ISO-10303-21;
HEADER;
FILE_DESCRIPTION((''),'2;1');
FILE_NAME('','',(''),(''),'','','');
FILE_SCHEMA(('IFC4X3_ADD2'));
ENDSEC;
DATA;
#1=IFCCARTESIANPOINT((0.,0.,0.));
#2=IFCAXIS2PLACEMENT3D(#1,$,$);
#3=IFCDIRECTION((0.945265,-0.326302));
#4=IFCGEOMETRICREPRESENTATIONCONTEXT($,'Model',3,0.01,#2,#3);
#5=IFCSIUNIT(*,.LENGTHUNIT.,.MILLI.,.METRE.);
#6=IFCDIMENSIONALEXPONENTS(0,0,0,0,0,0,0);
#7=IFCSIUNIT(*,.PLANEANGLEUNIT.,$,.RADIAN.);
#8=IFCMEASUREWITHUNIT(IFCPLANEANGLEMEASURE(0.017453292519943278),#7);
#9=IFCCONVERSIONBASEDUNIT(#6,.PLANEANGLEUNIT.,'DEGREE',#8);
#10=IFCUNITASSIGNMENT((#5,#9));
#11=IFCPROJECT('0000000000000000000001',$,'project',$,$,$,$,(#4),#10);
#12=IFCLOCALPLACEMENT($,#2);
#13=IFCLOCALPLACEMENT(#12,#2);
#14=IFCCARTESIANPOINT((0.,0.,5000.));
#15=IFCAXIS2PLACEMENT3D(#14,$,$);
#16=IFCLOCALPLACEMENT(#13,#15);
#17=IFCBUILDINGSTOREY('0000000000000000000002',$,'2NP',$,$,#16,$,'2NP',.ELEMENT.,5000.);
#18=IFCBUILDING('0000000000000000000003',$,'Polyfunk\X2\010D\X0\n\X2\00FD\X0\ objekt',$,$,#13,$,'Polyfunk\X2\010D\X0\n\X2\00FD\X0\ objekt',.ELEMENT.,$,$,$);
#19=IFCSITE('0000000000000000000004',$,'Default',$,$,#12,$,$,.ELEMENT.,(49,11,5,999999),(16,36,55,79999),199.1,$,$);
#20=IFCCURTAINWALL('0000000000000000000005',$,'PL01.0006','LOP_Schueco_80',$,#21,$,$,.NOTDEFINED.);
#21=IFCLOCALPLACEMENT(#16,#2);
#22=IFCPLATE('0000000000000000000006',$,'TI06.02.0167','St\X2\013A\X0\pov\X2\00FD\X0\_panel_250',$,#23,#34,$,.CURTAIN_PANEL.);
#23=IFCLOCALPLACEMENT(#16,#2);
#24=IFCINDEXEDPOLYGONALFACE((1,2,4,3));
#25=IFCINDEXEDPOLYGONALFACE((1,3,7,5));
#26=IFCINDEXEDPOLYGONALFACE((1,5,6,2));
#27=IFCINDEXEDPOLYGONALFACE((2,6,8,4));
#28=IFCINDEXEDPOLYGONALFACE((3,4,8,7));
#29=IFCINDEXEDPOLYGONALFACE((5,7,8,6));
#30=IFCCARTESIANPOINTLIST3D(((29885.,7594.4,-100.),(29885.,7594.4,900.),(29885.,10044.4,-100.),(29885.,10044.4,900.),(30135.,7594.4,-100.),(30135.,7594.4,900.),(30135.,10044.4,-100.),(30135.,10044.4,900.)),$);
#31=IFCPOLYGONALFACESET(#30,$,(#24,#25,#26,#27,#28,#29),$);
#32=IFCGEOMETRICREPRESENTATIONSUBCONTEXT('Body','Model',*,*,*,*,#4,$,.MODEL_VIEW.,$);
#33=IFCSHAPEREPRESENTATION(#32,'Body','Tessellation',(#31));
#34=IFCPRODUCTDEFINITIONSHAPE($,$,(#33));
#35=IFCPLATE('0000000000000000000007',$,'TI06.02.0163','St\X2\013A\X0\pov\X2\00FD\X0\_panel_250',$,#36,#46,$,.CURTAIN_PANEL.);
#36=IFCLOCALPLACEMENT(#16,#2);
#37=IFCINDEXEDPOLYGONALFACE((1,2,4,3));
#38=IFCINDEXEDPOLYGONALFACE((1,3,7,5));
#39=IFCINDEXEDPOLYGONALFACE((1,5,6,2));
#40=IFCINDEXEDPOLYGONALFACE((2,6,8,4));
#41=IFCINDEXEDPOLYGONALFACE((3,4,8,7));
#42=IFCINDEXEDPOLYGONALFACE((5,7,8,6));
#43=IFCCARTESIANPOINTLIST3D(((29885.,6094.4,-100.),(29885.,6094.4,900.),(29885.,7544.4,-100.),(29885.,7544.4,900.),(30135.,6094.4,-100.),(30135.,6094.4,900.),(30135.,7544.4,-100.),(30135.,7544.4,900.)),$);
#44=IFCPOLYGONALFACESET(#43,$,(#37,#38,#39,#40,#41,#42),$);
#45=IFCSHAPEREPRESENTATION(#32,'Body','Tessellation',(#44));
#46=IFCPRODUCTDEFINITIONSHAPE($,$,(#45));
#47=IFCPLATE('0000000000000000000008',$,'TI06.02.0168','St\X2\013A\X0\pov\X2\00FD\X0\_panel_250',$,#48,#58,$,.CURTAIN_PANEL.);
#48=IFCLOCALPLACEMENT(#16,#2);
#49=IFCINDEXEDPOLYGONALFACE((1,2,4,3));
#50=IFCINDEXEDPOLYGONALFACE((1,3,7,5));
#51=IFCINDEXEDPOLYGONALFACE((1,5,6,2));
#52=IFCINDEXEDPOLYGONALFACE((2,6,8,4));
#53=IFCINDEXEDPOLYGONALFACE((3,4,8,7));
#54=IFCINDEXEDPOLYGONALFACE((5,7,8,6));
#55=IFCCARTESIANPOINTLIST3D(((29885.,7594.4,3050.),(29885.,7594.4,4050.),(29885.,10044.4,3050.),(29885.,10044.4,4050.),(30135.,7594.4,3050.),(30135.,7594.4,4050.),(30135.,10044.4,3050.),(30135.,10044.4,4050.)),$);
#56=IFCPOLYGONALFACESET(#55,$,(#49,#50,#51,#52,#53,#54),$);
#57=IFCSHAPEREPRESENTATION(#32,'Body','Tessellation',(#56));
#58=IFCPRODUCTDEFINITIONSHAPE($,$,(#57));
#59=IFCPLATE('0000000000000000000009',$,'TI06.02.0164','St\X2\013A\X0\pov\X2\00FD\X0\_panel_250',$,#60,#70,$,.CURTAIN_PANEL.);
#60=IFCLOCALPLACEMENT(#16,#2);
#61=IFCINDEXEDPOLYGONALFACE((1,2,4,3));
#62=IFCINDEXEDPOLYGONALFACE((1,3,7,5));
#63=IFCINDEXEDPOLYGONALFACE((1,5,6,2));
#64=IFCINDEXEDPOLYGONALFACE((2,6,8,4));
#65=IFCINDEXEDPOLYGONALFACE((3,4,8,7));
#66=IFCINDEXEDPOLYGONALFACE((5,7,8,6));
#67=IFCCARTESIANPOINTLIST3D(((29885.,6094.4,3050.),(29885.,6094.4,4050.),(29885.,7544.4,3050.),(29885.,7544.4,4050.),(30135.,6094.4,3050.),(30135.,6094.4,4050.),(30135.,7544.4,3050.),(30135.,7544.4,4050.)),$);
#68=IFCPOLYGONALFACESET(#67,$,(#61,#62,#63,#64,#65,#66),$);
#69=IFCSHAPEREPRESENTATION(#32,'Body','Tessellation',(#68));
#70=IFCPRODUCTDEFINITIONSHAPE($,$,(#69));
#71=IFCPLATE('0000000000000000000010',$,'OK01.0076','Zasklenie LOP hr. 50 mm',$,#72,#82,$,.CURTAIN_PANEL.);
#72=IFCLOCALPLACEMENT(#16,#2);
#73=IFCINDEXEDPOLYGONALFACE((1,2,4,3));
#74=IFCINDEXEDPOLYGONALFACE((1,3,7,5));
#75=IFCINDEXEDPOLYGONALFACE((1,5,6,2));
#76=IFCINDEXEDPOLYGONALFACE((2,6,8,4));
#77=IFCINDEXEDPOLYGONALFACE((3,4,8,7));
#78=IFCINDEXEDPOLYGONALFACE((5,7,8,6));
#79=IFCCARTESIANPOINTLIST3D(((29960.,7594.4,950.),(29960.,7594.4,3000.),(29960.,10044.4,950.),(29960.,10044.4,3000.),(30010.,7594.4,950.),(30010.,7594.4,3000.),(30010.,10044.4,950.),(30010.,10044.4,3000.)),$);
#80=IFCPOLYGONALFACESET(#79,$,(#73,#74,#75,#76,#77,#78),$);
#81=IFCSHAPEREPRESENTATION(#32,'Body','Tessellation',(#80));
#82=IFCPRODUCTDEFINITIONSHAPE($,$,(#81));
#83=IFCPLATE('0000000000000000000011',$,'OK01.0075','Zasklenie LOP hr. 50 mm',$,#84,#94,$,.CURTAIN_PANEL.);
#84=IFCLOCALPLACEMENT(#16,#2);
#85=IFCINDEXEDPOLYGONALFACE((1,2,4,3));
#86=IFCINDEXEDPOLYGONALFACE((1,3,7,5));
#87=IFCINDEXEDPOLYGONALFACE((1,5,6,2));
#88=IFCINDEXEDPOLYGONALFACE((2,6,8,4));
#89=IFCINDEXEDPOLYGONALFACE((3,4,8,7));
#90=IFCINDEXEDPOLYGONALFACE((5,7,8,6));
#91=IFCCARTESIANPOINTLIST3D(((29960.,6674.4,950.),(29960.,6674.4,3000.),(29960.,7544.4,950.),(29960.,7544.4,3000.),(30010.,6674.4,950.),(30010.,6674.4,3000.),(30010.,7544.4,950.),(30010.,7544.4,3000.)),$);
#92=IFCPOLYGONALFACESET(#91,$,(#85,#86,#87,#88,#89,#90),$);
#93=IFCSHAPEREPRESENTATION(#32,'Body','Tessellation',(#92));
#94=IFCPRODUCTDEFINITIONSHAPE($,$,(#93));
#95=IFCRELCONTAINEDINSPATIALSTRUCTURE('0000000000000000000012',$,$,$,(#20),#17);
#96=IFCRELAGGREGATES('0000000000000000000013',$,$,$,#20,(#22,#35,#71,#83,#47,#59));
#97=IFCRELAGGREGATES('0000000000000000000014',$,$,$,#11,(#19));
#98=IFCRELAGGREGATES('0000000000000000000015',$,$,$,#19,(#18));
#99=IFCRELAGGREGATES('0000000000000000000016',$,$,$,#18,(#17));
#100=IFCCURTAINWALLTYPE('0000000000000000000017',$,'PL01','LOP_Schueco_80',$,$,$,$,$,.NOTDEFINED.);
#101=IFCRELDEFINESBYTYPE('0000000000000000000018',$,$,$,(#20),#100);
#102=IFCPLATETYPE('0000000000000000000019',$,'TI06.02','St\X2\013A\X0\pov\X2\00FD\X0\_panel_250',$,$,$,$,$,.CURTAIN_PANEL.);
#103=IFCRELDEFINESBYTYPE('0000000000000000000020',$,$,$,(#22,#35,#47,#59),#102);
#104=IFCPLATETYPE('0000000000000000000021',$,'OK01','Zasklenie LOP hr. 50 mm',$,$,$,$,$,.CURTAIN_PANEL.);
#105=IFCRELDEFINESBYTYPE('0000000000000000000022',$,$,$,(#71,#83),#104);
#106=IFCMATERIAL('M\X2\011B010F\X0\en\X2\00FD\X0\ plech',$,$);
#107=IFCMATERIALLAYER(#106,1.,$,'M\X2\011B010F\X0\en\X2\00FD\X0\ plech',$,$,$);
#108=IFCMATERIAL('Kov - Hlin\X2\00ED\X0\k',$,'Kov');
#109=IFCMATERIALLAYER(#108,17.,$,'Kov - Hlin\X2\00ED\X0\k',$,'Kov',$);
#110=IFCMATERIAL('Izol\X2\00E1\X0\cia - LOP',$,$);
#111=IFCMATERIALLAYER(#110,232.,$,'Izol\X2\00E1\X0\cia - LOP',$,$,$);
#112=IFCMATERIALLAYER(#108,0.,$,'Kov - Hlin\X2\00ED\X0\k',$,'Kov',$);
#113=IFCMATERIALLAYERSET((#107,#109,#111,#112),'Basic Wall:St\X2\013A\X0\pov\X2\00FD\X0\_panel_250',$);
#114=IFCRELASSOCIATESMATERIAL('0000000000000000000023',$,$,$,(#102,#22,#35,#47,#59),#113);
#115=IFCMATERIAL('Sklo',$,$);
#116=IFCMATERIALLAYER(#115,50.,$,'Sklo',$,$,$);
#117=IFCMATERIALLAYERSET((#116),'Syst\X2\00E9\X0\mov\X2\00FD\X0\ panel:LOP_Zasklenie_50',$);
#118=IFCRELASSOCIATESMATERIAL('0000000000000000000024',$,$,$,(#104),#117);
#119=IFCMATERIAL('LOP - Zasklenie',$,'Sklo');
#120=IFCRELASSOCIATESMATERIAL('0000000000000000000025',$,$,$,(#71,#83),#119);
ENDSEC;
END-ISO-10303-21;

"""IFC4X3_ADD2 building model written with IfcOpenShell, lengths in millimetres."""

from ifc_helpers import new_model, entity, si_unit, converted_unit, direction, frame, frame_2d, origin, origin_2d_with_axis, place, context, subcontext, project, spatial, rectangle, extrude, source, transform, mapped, material, layer, layer_set, layer_usage, type_object, type_shapes, element, aggregate, save


model = new_model("IFC4X3_ADD2")

# Units and contexts
model_context = context("Model", 3, precision=0.01, world=origin(), true_north=direction((0.945265, -0.326302)))
body_context = subcontext(model_context, "Body", "Model", "MODEL_VIEW")
ifc_project = project(units=[si_unit("LENGTHUNIT", "METRE", prefix="MILLI"), converted_unit("PLANEANGLEUNIT", "DEGREE", entity("IfcPlaneAngleMeasure", 0.017453292519943278), si_unit("PLANEANGLEUNIT", "RADIAN"), dimensions=[0, 0, 0, 0, 0, 0, 0])], contexts=[model_context])

# Site, building, storey
site_placement = place(None, origin())
site = spatial("IfcSite", under=ifc_project, at=site_placement, Name="Default", CompositionType="ELEMENT", RefLatitude=(49, 11, 5, 999999), RefLongitude=(16, 36, 55, 79999), RefElevation=199.1)
building_placement = place(site_placement, origin())
building = spatial("IfcBuilding", under=site, at=building_placement, Name="Polyfunkčný objekt", LongName="Polyfunkčný objekt", CompositionType="ELEMENT")
storey_placement = place(building_placement, frame((0.0, 0.0, 5000.0)))
storey = spatial("IfcBuildingStorey", under=building, at=storey_placement, Name="2NP", LongName="2NP", CompositionType="ELEMENT", Elevation=5000.0)

# Curtain wall, plates
curtain_wall_type = type_object("IfcCurtainWallType", Name="PL01", Description="LOP_Schueco_80", PredefinedType="NOTDEFINED")
curtain_wall_placement = place(storey_placement, frame((0.0, 0.0, -5000.0)))
curtain_wall = element("IfcCurtainWall", 1, at=curtain_wall_placement, inside=storey, type_object=curtain_wall_type, Name="PL01.0006", Description="LOP_Schueco_80", PredefinedType="NOTDEFINED")
ifc_material_1 = material(Name="Měďený plech")
ifc_layer_1 = layer(ifc_material_1, 1.0, Name="Měďený plech")
ifc_material_2 = material(Name="Kov - Hliník", Category="Kov")
ifc_layer_2 = layer(ifc_material_2, 17.0, Name="Kov - Hliník", Category="Kov")
ifc_material_3 = material(Name="Izolácia - LOP")
ifc_layer_3 = layer(ifc_material_3, 232.0, Name="Izolácia - LOP")
ifc_layer_4 = layer(ifc_material_2, 0.0, Name="Kov - Hliník", Category="Kov")
ifc_layer_set_1 = layer_set([ifc_layer_1, ifc_layer_2, ifc_layer_3, ifc_layer_4], Name="Basic Wall:Stĺpový_panel_250")
ifc_layer_usage_1 = layer_usage(ifc_layer_set_1, "AXIS2", "POSITIVE", -125.0)
plate_type_1 = type_object("IfcPlateType", Name="TI06.02", Description="Stĺpový_panel_250", PredefinedType="CURTAIN_PANEL", material=ifc_layer_set_1)
plate_1_placement = place(storey_placement, frame((30010.0, 10044.4, -100.0), z_axis=(0.0, 0.0, 1.0), x_axis=(0.0, -1.0, 0.0)))
plate_1 = element("IfcPlate", 2, at=plate_1_placement, type_object=plate_type_1, material=ifc_layer_usage_1, Name="TI06.02.0167", Description="Stĺpový_panel_250", PredefinedType="CURTAIN_PANEL", context=body_context, shape_type="SweptSolid", body=[
    extrude(rectangle(XDim=250.0, YDim=2450.0, at=origin_2d_with_axis()), frame((1225.0, 0.0, 0.0), z_axis=(0.0, 0.0, 1.0), x_axis=(0.0, 1.0, 0.0)), (0.0, 0.0, 1.0), 1000.0),
])
ifc_layer_usage_2 = layer_usage(ifc_layer_set_1, "AXIS2", "POSITIVE", -125.0)
plate_2_placement = place(storey_placement, frame((30010.0, 7544.4, -100.0), z_axis=(0.0, 0.0, 1.0), x_axis=(0.0, -1.0, 0.0)))
plate_2 = element("IfcPlate", 3, at=plate_2_placement, type_object=plate_type_1, material=ifc_layer_usage_2, Name="TI06.02.0163", Description="Stĺpový_panel_250", PredefinedType="CURTAIN_PANEL", context=body_context, shape_type="SweptSolid", body=[
    extrude(rectangle(XDim=250.0, YDim=1450.0, at=frame_2d((0.0, 0.0), x_axis=(1.0, 0.0))), frame((725.0, 0.0, 0.0), z_axis=(0.0, 0.0, 1.0), x_axis=(0.0, 1.0, 0.0)), (0.0, 0.0, 1.0), 1000.0),
])
ifc_layer_usage_3 = layer_usage(ifc_layer_set_1, "AXIS2", "POSITIVE", -125.0)
plate_3_placement = place(storey_placement, frame((30010.0, 10044.4, 3050.0), z_axis=(0.0, 0.0, 1.0), x_axis=(0.0, -1.0, 0.0)))
plate_3 = element("IfcPlate", 4, at=plate_3_placement, type_object=plate_type_1, material=ifc_layer_usage_3, Name="TI06.02.0168", Description="Stĺpový_panel_250", PredefinedType="CURTAIN_PANEL", context=body_context, shape_type="SweptSolid", body=[
    extrude(rectangle(XDim=250.0, YDim=2450.0, at=origin_2d_with_axis()), frame((1225.0, 0.0, 0.0), z_axis=(0.0, 0.0, 1.0), x_axis=(0.0, 1.0, 0.0)), (0.0, 0.0, 1.0), 1000.0),
])
ifc_layer_usage_4 = layer_usage(ifc_layer_set_1, "AXIS2", "POSITIVE", -125.0)
plate_4_placement = place(storey_placement, frame((30010.0, 7544.4, 3050.0), z_axis=(0.0, 0.0, 1.0), x_axis=(0.0, -1.0, 0.0)))
plate_4 = element("IfcPlate", 5, at=plate_4_placement, type_object=plate_type_1, material=ifc_layer_usage_4, Name="TI06.02.0164", Description="Stĺpový_panel_250", PredefinedType="CURTAIN_PANEL", context=body_context, shape_type="SweptSolid", body=[
    extrude(rectangle(XDim=250.0, YDim=1450.0, at=frame_2d((0.0, 0.0), x_axis=(1.0, 0.0))), frame((725.0, 0.0, 0.0), z_axis=(0.0, 0.0, 1.0), x_axis=(0.0, 1.0, 0.0)), (0.0, 0.0, 1.0), 1000.0),
])
ifc_material_4 = material(Name="LOP - Zasklenie", Category="Sklo")
ifc_material_5 = material(Name="Sklo")
ifc_layer_5 = layer(ifc_material_5, 50.0, Name="Sklo")
ifc_layer_set_2 = layer_set([ifc_layer_5], Name="Systémový panel:LOP_Zasklenie_50")
plate_type_2 = type_object("IfcPlateType", Name="OK01", Description="Zasklenie LOP hr. 50 mm", PredefinedType="CURTAIN_PANEL", material=ifc_layer_set_2)
shared_shape_1 = source(origin(), body_context, "Body", "SweptSolid", [
    extrude(rectangle(XDim=50.0, YDim=2450.0, at=origin_2d_with_axis()), frame((0.0, -25.0, 0.0), z_axis=(0.0, 0.0, 1.0), x_axis=(0.0, 1.0, 0.0)), (0.0, 0.0, 1.0), 2050.0),
])
plate_5_placement = place(curtain_wall_placement, frame((30010.0, 8819.4, 5950.0), z_axis=(0.0, 0.0, 1.0), x_axis=(0.0, -1.0, 0.0)))
plate_5 = element("IfcPlate", 6, at=plate_5_placement, type_object=plate_type_2, material=ifc_material_4, Name="OK01.0076", Description="Zasklenie LOP hr. 50 mm", PredefinedType="CURTAIN_PANEL", context=body_context, shape_type="MappedRepresentation", body=[
    mapped(shared_shape_1, transform((0.0, 0.0, 0.0), scale=1.0)),
])
shared_shape_2 = source(origin(), body_context, "Body", "SweptSolid", [
    extrude(rectangle(XDim=50.0, YDim=870.0, at=origin_2d_with_axis()), frame((0.0, -25.0, 0.0), z_axis=(0.0, 0.0, 1.0), x_axis=(0.0, 1.0, 0.0)), (0.0, 0.0, 1.0), 2050.0),
])
type_shapes(plate_type_2, [shared_shape_1, shared_shape_2])
plate_6_placement = place(curtain_wall_placement, frame((30010.0, 7109.4, 5950.0), z_axis=(0.0, 0.0, 1.0), x_axis=(0.0, -1.0, 0.0)))
plate_6 = element("IfcPlate", 7, at=plate_6_placement, type_object=plate_type_2, material=ifc_material_4, Name="OK01.0075", Description="Zasklenie LOP hr. 50 mm", PredefinedType="CURTAIN_PANEL", context=body_context, shape_type="MappedRepresentation", body=[
    mapped(shared_shape_2, transform((0.0, 0.0, 0.0), scale=1.0)),
])
aggregate(curtain_wall, [plate_1, plate_2, plate_5, plate_6, plate_3, plate_4])

save(model, "model.ifc")
